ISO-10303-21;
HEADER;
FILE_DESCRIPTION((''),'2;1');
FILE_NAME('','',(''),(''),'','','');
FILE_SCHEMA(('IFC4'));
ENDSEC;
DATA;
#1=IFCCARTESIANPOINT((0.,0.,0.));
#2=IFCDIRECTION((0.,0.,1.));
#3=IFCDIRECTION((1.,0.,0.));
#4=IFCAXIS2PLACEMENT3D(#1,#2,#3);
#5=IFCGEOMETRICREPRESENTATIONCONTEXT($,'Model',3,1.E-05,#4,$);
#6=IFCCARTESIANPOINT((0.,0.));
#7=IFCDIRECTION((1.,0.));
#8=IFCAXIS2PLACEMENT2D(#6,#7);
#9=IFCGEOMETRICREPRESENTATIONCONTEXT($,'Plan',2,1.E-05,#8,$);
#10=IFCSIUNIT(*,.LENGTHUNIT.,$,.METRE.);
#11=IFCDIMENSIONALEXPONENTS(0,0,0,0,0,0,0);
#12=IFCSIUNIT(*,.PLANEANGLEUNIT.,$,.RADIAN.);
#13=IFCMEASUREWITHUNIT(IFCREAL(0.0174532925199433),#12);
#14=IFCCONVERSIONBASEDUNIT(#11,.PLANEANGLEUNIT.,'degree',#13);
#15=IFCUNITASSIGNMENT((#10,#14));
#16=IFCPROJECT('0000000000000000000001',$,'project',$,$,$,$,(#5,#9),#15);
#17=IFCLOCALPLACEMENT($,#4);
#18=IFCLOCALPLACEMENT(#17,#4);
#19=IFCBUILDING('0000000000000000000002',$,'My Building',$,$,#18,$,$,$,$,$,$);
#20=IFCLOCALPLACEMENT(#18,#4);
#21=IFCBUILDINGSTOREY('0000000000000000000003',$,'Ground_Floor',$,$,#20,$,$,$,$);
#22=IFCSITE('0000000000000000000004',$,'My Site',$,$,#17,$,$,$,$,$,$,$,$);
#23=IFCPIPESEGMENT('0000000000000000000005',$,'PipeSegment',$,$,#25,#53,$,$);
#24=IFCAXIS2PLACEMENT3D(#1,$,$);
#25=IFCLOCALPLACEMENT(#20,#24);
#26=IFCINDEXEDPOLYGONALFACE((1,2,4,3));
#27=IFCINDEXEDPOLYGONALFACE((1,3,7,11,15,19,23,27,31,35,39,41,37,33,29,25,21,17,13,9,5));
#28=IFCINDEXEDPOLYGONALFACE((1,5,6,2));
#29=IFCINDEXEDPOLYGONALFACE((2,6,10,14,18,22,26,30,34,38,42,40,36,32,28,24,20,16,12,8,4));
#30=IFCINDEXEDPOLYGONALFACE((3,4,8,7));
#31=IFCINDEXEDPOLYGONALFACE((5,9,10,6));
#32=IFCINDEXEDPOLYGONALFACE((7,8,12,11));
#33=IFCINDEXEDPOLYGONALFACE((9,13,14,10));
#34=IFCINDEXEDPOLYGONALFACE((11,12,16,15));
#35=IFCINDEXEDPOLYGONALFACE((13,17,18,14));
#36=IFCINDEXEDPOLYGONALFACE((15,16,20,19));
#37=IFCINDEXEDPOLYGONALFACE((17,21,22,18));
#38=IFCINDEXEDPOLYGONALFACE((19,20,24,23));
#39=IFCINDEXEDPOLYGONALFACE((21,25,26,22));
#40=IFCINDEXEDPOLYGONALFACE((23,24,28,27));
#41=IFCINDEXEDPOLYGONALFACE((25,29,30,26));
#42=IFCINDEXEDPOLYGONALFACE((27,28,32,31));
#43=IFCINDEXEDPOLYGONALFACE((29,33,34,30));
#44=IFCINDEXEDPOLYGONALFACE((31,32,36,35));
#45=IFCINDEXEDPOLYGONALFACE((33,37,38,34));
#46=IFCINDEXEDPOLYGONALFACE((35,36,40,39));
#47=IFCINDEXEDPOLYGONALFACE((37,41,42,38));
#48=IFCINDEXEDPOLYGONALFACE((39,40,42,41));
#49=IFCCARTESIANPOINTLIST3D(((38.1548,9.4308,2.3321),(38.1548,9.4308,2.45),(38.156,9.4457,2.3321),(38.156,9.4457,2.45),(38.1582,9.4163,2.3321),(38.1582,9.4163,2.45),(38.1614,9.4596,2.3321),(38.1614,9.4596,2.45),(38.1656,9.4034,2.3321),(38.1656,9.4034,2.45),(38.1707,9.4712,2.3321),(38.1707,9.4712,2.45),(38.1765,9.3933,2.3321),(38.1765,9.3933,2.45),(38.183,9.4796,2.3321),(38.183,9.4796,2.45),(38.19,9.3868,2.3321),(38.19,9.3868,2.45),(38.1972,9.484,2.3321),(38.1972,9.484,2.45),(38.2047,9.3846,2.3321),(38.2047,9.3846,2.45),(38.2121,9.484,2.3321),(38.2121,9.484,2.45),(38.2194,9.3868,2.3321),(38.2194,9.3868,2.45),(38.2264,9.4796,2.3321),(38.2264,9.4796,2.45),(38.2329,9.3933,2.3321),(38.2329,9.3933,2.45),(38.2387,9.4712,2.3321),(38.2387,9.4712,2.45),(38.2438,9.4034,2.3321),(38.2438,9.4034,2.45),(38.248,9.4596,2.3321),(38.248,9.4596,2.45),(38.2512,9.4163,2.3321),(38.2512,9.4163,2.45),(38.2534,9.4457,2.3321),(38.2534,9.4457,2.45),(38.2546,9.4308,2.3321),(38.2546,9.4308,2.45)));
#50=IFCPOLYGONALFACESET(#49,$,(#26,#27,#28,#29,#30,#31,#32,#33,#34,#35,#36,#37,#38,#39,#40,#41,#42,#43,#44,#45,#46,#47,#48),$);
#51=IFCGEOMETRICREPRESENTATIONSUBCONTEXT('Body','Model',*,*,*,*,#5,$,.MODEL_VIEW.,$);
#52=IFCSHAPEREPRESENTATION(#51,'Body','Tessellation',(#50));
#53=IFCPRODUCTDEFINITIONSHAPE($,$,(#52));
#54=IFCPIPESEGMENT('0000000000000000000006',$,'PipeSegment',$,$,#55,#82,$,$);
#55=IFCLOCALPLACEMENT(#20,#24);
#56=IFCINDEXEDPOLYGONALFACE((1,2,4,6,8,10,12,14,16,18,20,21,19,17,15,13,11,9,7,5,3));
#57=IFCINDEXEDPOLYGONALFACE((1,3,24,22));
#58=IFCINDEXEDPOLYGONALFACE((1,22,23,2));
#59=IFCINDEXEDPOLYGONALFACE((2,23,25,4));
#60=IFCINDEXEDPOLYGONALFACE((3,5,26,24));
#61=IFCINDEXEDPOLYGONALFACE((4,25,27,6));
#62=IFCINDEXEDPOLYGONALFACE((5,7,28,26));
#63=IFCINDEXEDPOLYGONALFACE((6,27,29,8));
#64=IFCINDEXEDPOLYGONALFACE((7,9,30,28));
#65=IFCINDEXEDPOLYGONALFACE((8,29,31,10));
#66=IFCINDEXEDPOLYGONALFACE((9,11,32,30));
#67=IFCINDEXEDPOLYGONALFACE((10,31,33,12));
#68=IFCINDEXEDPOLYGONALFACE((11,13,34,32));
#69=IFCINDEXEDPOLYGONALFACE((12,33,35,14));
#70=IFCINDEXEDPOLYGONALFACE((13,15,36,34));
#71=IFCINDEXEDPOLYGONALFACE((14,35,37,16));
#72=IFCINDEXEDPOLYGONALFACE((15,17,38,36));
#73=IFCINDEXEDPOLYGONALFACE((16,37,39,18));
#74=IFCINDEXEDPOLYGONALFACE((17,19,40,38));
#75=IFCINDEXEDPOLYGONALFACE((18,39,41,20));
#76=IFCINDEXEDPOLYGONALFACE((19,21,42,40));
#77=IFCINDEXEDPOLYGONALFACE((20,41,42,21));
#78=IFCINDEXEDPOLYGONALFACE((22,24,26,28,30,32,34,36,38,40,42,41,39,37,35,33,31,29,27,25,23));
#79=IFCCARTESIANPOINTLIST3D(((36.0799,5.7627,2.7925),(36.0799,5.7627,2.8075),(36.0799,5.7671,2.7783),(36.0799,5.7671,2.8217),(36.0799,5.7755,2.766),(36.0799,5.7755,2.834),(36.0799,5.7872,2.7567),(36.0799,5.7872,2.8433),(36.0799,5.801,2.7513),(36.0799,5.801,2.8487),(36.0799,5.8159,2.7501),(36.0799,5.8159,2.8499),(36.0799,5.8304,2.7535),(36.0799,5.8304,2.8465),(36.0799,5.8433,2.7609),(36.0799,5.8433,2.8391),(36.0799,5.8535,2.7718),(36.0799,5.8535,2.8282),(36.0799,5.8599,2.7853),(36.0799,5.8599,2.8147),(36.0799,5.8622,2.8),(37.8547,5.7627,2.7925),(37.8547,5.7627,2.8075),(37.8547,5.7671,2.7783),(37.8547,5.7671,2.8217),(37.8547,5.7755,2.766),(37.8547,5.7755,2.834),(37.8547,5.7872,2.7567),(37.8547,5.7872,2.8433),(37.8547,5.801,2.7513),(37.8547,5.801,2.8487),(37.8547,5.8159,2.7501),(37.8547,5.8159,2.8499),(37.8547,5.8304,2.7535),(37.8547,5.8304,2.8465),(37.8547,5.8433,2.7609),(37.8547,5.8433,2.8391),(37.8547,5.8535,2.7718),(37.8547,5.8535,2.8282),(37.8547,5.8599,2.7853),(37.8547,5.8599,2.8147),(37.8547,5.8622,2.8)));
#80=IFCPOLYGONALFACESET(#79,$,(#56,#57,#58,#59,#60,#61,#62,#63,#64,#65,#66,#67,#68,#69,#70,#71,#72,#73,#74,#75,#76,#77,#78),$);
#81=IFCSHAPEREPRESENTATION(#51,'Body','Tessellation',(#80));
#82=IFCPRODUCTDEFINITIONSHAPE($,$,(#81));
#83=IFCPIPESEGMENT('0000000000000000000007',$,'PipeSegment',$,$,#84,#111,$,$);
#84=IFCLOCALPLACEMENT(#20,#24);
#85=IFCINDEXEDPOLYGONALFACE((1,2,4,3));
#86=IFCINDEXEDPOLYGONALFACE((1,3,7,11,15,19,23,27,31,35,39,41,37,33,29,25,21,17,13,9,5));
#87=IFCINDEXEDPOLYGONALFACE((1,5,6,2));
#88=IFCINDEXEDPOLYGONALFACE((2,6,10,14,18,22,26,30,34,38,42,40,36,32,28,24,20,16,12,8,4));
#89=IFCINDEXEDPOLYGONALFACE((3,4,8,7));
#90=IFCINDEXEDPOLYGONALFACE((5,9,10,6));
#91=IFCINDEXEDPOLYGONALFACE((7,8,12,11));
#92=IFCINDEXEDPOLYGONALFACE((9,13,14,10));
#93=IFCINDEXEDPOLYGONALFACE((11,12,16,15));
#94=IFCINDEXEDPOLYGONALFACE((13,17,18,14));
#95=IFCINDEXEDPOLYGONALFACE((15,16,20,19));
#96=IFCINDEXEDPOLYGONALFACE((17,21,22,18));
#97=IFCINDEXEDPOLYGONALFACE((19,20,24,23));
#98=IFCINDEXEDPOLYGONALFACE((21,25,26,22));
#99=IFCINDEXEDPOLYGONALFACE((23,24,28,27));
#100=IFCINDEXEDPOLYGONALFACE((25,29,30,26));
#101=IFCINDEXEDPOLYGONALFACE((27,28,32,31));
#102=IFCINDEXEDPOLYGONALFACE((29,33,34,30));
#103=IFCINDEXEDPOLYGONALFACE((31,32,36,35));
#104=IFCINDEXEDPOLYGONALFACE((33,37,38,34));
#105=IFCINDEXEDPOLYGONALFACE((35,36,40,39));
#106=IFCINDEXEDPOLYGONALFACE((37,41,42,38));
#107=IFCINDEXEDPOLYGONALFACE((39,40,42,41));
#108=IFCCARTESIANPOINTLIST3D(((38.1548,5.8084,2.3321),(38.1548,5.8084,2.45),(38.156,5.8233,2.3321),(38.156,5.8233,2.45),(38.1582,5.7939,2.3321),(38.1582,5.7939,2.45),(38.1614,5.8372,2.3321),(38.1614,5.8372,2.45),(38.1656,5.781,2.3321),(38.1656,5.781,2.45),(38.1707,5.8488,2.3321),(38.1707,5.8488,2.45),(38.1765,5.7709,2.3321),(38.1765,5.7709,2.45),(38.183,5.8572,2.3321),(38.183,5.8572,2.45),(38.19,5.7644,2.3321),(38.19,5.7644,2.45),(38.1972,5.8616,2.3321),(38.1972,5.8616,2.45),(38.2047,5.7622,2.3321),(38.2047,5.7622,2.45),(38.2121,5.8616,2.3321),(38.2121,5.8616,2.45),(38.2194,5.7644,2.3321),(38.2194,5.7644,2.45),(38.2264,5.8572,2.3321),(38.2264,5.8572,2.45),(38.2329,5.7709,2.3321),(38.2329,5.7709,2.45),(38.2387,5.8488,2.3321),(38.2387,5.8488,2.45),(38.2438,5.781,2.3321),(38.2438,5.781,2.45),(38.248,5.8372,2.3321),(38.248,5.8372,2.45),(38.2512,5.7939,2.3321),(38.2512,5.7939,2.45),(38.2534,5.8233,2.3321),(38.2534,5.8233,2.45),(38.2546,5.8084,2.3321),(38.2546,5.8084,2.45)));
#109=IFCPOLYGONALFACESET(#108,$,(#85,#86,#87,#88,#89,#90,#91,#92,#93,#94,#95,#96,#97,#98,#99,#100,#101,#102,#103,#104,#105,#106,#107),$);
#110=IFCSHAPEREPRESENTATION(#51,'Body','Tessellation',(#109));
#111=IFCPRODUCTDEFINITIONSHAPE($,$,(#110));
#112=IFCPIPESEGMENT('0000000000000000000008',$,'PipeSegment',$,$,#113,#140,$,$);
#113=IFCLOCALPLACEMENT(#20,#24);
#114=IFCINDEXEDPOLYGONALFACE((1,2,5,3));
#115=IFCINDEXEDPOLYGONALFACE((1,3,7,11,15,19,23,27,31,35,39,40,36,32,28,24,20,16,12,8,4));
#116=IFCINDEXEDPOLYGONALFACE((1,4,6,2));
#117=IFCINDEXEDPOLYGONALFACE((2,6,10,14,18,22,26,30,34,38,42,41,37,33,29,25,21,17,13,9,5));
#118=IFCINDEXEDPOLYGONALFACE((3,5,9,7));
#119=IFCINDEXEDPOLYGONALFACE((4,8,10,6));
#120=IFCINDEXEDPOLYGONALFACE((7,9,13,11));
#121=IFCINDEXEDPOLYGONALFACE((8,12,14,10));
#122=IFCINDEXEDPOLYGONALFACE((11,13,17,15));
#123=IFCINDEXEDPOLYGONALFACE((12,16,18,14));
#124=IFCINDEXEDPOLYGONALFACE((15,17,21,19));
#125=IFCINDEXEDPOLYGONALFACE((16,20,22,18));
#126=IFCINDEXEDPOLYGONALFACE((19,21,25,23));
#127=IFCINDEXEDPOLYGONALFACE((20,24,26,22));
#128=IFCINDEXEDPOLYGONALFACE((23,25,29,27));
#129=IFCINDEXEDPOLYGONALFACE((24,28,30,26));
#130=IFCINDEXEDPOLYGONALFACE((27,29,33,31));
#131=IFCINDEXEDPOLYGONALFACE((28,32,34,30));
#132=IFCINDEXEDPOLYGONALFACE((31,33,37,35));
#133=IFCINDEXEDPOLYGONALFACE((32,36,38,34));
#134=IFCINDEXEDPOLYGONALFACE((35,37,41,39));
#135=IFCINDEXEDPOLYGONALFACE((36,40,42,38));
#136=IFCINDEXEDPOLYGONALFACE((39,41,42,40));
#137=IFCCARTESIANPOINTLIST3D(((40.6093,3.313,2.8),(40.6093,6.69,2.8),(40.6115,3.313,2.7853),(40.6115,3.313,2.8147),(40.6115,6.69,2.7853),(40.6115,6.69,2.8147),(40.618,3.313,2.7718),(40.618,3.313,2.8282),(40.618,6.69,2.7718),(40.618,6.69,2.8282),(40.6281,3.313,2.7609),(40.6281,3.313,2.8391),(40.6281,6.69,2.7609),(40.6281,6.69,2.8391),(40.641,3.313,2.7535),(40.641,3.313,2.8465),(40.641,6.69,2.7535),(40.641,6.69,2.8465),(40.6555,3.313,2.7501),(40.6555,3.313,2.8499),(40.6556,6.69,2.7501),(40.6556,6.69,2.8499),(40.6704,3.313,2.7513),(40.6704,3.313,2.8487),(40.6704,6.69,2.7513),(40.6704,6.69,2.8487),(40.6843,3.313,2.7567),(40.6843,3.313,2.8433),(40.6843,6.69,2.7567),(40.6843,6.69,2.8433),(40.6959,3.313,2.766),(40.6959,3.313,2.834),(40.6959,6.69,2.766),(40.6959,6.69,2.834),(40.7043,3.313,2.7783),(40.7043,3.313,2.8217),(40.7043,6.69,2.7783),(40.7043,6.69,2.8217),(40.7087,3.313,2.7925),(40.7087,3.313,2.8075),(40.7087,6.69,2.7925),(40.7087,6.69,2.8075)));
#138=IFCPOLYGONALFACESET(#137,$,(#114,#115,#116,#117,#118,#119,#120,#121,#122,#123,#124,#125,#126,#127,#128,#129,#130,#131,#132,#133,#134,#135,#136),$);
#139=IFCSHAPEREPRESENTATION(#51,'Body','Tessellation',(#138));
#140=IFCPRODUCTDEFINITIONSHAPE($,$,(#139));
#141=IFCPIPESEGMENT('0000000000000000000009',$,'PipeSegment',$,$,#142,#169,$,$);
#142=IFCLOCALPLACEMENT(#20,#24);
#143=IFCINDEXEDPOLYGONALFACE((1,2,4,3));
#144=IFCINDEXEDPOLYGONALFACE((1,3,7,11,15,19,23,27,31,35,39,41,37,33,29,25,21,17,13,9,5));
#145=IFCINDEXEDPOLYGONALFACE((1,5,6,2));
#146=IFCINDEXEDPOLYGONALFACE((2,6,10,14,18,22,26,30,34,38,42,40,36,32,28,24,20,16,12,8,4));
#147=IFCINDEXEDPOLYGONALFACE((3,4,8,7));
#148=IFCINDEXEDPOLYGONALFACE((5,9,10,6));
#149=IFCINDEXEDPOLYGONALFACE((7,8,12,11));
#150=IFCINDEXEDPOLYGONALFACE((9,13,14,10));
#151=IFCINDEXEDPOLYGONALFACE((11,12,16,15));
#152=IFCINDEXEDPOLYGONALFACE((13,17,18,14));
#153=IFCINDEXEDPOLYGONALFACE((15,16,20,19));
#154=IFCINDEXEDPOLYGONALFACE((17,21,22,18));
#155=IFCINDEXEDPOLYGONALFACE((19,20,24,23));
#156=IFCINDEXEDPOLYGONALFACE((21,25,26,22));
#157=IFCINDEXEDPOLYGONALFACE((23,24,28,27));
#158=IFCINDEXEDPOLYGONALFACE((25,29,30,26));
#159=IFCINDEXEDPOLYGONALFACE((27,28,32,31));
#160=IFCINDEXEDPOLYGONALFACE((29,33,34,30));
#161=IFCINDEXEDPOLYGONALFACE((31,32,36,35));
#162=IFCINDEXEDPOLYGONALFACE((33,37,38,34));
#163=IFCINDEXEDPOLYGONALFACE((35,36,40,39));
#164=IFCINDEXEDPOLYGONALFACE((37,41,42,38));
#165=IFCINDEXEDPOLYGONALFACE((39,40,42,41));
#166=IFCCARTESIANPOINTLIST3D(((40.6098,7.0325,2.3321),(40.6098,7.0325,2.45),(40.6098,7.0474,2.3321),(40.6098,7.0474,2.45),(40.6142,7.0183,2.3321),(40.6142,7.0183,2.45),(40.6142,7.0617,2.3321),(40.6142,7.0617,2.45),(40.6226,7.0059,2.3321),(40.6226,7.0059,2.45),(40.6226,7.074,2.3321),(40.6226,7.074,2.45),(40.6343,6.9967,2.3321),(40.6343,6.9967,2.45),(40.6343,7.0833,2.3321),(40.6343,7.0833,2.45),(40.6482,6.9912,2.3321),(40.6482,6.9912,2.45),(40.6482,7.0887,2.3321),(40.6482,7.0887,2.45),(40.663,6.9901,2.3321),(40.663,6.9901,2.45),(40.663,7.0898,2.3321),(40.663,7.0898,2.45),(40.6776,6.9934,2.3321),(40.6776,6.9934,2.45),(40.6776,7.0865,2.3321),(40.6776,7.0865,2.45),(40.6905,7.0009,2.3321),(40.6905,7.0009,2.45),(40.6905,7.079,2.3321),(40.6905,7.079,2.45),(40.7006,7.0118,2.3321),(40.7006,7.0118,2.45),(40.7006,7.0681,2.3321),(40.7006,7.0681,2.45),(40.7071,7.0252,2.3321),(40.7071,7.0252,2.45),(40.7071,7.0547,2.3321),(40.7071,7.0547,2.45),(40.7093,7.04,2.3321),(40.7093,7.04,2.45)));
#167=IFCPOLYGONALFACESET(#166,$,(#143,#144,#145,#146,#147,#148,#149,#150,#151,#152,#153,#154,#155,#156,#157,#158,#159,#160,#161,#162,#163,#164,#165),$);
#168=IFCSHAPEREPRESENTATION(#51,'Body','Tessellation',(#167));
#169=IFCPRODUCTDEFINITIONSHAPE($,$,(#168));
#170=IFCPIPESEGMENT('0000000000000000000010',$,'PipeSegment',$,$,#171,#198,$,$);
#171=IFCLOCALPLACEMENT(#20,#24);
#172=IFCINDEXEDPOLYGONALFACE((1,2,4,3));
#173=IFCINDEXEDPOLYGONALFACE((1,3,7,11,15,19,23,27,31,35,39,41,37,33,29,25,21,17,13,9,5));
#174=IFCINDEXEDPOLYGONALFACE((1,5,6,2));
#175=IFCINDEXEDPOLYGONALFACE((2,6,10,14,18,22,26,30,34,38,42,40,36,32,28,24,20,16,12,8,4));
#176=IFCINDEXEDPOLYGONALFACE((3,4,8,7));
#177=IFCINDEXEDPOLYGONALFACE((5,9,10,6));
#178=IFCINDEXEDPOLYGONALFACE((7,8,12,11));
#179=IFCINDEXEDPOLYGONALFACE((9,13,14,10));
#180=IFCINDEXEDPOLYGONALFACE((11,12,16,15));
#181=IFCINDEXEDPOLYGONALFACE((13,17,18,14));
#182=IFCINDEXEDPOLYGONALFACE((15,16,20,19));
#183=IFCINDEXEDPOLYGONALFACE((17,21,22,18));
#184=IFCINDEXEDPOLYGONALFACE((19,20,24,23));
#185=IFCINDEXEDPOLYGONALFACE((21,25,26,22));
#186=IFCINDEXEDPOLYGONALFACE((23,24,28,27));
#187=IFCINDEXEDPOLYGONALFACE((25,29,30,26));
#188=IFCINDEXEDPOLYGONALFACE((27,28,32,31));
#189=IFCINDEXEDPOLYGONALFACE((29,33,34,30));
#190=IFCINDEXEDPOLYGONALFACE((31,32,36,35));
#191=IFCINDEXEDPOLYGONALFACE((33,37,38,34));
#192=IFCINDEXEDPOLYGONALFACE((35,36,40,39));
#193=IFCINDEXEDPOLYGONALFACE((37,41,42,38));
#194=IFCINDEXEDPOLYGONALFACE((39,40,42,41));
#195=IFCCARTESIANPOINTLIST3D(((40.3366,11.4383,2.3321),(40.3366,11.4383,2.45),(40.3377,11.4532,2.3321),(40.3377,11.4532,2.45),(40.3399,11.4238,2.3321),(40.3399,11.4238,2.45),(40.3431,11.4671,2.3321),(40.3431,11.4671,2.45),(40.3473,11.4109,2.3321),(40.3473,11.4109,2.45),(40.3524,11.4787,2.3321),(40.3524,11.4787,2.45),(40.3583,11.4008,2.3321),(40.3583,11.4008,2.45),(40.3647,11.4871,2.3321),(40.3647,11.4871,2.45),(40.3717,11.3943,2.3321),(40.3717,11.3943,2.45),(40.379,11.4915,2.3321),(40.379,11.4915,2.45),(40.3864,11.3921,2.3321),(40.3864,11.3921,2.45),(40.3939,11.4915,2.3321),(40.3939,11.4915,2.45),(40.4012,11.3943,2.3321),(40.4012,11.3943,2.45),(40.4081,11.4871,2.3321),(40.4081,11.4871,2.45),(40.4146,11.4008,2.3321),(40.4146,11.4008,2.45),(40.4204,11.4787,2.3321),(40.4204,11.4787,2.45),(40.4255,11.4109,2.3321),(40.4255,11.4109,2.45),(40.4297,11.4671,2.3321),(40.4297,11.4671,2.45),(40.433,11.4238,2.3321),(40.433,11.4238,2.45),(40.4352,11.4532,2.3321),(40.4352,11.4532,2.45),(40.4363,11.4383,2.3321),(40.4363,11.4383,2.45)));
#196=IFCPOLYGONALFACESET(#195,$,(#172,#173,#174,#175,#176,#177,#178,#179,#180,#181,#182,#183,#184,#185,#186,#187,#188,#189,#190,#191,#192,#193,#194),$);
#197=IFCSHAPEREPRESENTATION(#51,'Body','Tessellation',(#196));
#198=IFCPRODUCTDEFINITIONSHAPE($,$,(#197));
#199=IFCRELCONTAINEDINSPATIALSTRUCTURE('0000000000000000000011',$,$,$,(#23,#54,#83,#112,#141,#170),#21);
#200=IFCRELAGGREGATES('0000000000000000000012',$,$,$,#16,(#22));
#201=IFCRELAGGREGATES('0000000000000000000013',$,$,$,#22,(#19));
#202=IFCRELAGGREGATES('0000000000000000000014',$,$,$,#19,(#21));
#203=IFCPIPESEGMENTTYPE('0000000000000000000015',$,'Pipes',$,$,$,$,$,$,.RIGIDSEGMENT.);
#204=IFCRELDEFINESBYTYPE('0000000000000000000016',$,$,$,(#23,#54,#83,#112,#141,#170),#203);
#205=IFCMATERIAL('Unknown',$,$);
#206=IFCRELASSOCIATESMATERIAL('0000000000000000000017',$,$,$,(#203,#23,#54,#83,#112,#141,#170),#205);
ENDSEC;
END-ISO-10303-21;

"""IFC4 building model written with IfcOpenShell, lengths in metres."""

from ifc_helpers import new_model, entity, si_unit, converted_unit, frame, origin_with_axes, origin_2d_with_axis, place, context, subcontext, project, spatial, circle, extrude, material, material_profile, profile_set, profile_usage, type_object, element, save


model = new_model("IFC4")

# Units and contexts
model_context = context("Model", 3, precision=1e-05, world=origin_with_axes())
plan_context = context("Plan", 2, precision=1e-05, world=origin_2d_with_axis())
body_context = subcontext(model_context, "Body", "Model", "MODEL_VIEW")
ifc_project = project(units=[si_unit("LENGTHUNIT", "METRE"), converted_unit("PLANEANGLEUNIT", "degree", entity("IfcReal", 0.0174532925199433), si_unit("PLANEANGLEUNIT", "RADIAN"), dimensions=[0, 0, 0, 0, 0, 0, 0])], contexts=[model_context, plan_context])

# Site, building, storey
site_placement = place(None, origin_with_axes())
site = spatial("IfcSite", under=ifc_project, at=site_placement, Name="My Site")
building_placement = place(site_placement, origin_with_axes())
building = spatial("IfcBuilding", under=site, at=building_placement, Name="My Building")
storey_placement = place(building_placement, origin_with_axes())
storey = spatial("IfcBuildingStorey", under=building, at=storey_placement, Name="Ground_Floor")

# Shared definitions
ifc_material = material(Name="Unknown")

# Pipe segments
ifc_material_profile_1 = material_profile(ifc_material, circle(Radius=0.05))
ifc_profile_set_1 = profile_set([ifc_material_profile_1])
pipe_segment_type = type_object("IfcPipeSegmentType", Name="Pipes", PredefinedType="RIGIDSEGMENT", material=ifc_profile_set_1)
ifc_profile_usage_1 = profile_usage(ifc_profile_set_1, cardinal=5)
pipe_segment_1_placement = place(storey_placement, frame((38.2047, 9.4346, 2.45), z_axis=(0.0, 0.0, -1.0), x_axis=(0.0, -1.0, 0.0)))
element("IfcPipeSegment", 1, at=pipe_segment_1_placement, inside=storey, type_object=pipe_segment_type, material=ifc_profile_usage_1, Name="PipeSegment", context=body_context, shape_type="SweptSolid", body=[
    extrude(circle(Radius=0.05), origin_with_axes(), (0.0, 0.0, 1.0), 0.1179),
])
ifc_profile_usage_2 = profile_usage(ifc_profile_set_1, cardinal=5)
pipe_segment_2_placement = place(storey_placement, frame((36.0799, 5.8122, 2.8), z_axis=(1.0, 0.0, 0.0), x_axis=(0.0, 1.0, 0.0)))
element("IfcPipeSegment", 2, at=pipe_segment_2_placement, inside=storey, type_object=pipe_segment_type, material=ifc_profile_usage_2, Name="PipeSegment", context=body_context, shape_type="SweptSolid", body=[
    extrude(circle(Radius=0.05), origin_with_axes(), (0.0, 0.0, 1.0), 1.7748),
])
ifc_profile_usage_3 = profile_usage(ifc_profile_set_1, cardinal=5)
pipe_segment_3_placement = place(storey_placement, frame((38.2047, 5.8122, 2.45), z_axis=(0.0, 0.0, -1.0), x_axis=(0.0, -1.0, 0.0)))
element("IfcPipeSegment", 3, at=pipe_segment_3_placement, inside=storey, type_object=pipe_segment_type, material=ifc_profile_usage_3, Name="PipeSegment", context=body_context, shape_type="SweptSolid", body=[
    extrude(circle(Radius=0.05), origin_with_axes(), (0.0, 0.0, 1.0), 0.1179),
])
ifc_profile_usage_4 = profile_usage(ifc_profile_set_1, cardinal=5)
pipe_segment_4_placement = place(storey_placement, frame((40.6593, 3.313, 2.8), z_axis=(0.000001, 1.0, 0.0), x_axis=(-1.0, 0.000001, 0.0)))
element("IfcPipeSegment", 4, at=pipe_segment_4_placement, inside=storey, type_object=pipe_segment_type, material=ifc_profile_usage_4, Name="PipeSegment", context=body_context, shape_type="SweptSolid", body=[
    extrude(circle(Radius=0.05), origin_with_axes(), (0.0, 0.0, 1.0), 3.377),
])
ifc_profile_usage_5 = profile_usage(ifc_profile_set_1, cardinal=5)
pipe_segment_5_placement = place(storey_placement, frame((40.6593, 7.04, 2.45), z_axis=(0.0, 0.000001, -1.0), x_axis=(1.0, 0.0, 0.0)))
element("IfcPipeSegment", 5, at=pipe_segment_5_placement, inside=storey, type_object=pipe_segment_type, material=ifc_profile_usage_5, Name="PipeSegment", context=body_context, shape_type="SweptSolid", body=[
    extrude(circle(Radius=0.05), origin_with_axes(), (0.0, 0.0, 1.0), 0.1179),
])
ifc_profile_usage_6 = profile_usage(ifc_profile_set_1, cardinal=5)
pipe_segment_6_placement = place(storey_placement, frame((40.3864, 11.4421, 2.45), z_axis=(0.000001, 0.0, -1.0), x_axis=(0.0, -1.0, 0.0)))
element("IfcPipeSegment", 6, at=pipe_segment_6_placement, inside=storey, type_object=pipe_segment_type, material=ifc_profile_usage_6, Name="PipeSegment", context=body_context, shape_type="SweptSolid", body=[
    extrude(circle(Radius=0.05), origin_with_axes(), (0.0, 0.0, 1.0), 0.1179),
])

save(model, "model.ifc")
